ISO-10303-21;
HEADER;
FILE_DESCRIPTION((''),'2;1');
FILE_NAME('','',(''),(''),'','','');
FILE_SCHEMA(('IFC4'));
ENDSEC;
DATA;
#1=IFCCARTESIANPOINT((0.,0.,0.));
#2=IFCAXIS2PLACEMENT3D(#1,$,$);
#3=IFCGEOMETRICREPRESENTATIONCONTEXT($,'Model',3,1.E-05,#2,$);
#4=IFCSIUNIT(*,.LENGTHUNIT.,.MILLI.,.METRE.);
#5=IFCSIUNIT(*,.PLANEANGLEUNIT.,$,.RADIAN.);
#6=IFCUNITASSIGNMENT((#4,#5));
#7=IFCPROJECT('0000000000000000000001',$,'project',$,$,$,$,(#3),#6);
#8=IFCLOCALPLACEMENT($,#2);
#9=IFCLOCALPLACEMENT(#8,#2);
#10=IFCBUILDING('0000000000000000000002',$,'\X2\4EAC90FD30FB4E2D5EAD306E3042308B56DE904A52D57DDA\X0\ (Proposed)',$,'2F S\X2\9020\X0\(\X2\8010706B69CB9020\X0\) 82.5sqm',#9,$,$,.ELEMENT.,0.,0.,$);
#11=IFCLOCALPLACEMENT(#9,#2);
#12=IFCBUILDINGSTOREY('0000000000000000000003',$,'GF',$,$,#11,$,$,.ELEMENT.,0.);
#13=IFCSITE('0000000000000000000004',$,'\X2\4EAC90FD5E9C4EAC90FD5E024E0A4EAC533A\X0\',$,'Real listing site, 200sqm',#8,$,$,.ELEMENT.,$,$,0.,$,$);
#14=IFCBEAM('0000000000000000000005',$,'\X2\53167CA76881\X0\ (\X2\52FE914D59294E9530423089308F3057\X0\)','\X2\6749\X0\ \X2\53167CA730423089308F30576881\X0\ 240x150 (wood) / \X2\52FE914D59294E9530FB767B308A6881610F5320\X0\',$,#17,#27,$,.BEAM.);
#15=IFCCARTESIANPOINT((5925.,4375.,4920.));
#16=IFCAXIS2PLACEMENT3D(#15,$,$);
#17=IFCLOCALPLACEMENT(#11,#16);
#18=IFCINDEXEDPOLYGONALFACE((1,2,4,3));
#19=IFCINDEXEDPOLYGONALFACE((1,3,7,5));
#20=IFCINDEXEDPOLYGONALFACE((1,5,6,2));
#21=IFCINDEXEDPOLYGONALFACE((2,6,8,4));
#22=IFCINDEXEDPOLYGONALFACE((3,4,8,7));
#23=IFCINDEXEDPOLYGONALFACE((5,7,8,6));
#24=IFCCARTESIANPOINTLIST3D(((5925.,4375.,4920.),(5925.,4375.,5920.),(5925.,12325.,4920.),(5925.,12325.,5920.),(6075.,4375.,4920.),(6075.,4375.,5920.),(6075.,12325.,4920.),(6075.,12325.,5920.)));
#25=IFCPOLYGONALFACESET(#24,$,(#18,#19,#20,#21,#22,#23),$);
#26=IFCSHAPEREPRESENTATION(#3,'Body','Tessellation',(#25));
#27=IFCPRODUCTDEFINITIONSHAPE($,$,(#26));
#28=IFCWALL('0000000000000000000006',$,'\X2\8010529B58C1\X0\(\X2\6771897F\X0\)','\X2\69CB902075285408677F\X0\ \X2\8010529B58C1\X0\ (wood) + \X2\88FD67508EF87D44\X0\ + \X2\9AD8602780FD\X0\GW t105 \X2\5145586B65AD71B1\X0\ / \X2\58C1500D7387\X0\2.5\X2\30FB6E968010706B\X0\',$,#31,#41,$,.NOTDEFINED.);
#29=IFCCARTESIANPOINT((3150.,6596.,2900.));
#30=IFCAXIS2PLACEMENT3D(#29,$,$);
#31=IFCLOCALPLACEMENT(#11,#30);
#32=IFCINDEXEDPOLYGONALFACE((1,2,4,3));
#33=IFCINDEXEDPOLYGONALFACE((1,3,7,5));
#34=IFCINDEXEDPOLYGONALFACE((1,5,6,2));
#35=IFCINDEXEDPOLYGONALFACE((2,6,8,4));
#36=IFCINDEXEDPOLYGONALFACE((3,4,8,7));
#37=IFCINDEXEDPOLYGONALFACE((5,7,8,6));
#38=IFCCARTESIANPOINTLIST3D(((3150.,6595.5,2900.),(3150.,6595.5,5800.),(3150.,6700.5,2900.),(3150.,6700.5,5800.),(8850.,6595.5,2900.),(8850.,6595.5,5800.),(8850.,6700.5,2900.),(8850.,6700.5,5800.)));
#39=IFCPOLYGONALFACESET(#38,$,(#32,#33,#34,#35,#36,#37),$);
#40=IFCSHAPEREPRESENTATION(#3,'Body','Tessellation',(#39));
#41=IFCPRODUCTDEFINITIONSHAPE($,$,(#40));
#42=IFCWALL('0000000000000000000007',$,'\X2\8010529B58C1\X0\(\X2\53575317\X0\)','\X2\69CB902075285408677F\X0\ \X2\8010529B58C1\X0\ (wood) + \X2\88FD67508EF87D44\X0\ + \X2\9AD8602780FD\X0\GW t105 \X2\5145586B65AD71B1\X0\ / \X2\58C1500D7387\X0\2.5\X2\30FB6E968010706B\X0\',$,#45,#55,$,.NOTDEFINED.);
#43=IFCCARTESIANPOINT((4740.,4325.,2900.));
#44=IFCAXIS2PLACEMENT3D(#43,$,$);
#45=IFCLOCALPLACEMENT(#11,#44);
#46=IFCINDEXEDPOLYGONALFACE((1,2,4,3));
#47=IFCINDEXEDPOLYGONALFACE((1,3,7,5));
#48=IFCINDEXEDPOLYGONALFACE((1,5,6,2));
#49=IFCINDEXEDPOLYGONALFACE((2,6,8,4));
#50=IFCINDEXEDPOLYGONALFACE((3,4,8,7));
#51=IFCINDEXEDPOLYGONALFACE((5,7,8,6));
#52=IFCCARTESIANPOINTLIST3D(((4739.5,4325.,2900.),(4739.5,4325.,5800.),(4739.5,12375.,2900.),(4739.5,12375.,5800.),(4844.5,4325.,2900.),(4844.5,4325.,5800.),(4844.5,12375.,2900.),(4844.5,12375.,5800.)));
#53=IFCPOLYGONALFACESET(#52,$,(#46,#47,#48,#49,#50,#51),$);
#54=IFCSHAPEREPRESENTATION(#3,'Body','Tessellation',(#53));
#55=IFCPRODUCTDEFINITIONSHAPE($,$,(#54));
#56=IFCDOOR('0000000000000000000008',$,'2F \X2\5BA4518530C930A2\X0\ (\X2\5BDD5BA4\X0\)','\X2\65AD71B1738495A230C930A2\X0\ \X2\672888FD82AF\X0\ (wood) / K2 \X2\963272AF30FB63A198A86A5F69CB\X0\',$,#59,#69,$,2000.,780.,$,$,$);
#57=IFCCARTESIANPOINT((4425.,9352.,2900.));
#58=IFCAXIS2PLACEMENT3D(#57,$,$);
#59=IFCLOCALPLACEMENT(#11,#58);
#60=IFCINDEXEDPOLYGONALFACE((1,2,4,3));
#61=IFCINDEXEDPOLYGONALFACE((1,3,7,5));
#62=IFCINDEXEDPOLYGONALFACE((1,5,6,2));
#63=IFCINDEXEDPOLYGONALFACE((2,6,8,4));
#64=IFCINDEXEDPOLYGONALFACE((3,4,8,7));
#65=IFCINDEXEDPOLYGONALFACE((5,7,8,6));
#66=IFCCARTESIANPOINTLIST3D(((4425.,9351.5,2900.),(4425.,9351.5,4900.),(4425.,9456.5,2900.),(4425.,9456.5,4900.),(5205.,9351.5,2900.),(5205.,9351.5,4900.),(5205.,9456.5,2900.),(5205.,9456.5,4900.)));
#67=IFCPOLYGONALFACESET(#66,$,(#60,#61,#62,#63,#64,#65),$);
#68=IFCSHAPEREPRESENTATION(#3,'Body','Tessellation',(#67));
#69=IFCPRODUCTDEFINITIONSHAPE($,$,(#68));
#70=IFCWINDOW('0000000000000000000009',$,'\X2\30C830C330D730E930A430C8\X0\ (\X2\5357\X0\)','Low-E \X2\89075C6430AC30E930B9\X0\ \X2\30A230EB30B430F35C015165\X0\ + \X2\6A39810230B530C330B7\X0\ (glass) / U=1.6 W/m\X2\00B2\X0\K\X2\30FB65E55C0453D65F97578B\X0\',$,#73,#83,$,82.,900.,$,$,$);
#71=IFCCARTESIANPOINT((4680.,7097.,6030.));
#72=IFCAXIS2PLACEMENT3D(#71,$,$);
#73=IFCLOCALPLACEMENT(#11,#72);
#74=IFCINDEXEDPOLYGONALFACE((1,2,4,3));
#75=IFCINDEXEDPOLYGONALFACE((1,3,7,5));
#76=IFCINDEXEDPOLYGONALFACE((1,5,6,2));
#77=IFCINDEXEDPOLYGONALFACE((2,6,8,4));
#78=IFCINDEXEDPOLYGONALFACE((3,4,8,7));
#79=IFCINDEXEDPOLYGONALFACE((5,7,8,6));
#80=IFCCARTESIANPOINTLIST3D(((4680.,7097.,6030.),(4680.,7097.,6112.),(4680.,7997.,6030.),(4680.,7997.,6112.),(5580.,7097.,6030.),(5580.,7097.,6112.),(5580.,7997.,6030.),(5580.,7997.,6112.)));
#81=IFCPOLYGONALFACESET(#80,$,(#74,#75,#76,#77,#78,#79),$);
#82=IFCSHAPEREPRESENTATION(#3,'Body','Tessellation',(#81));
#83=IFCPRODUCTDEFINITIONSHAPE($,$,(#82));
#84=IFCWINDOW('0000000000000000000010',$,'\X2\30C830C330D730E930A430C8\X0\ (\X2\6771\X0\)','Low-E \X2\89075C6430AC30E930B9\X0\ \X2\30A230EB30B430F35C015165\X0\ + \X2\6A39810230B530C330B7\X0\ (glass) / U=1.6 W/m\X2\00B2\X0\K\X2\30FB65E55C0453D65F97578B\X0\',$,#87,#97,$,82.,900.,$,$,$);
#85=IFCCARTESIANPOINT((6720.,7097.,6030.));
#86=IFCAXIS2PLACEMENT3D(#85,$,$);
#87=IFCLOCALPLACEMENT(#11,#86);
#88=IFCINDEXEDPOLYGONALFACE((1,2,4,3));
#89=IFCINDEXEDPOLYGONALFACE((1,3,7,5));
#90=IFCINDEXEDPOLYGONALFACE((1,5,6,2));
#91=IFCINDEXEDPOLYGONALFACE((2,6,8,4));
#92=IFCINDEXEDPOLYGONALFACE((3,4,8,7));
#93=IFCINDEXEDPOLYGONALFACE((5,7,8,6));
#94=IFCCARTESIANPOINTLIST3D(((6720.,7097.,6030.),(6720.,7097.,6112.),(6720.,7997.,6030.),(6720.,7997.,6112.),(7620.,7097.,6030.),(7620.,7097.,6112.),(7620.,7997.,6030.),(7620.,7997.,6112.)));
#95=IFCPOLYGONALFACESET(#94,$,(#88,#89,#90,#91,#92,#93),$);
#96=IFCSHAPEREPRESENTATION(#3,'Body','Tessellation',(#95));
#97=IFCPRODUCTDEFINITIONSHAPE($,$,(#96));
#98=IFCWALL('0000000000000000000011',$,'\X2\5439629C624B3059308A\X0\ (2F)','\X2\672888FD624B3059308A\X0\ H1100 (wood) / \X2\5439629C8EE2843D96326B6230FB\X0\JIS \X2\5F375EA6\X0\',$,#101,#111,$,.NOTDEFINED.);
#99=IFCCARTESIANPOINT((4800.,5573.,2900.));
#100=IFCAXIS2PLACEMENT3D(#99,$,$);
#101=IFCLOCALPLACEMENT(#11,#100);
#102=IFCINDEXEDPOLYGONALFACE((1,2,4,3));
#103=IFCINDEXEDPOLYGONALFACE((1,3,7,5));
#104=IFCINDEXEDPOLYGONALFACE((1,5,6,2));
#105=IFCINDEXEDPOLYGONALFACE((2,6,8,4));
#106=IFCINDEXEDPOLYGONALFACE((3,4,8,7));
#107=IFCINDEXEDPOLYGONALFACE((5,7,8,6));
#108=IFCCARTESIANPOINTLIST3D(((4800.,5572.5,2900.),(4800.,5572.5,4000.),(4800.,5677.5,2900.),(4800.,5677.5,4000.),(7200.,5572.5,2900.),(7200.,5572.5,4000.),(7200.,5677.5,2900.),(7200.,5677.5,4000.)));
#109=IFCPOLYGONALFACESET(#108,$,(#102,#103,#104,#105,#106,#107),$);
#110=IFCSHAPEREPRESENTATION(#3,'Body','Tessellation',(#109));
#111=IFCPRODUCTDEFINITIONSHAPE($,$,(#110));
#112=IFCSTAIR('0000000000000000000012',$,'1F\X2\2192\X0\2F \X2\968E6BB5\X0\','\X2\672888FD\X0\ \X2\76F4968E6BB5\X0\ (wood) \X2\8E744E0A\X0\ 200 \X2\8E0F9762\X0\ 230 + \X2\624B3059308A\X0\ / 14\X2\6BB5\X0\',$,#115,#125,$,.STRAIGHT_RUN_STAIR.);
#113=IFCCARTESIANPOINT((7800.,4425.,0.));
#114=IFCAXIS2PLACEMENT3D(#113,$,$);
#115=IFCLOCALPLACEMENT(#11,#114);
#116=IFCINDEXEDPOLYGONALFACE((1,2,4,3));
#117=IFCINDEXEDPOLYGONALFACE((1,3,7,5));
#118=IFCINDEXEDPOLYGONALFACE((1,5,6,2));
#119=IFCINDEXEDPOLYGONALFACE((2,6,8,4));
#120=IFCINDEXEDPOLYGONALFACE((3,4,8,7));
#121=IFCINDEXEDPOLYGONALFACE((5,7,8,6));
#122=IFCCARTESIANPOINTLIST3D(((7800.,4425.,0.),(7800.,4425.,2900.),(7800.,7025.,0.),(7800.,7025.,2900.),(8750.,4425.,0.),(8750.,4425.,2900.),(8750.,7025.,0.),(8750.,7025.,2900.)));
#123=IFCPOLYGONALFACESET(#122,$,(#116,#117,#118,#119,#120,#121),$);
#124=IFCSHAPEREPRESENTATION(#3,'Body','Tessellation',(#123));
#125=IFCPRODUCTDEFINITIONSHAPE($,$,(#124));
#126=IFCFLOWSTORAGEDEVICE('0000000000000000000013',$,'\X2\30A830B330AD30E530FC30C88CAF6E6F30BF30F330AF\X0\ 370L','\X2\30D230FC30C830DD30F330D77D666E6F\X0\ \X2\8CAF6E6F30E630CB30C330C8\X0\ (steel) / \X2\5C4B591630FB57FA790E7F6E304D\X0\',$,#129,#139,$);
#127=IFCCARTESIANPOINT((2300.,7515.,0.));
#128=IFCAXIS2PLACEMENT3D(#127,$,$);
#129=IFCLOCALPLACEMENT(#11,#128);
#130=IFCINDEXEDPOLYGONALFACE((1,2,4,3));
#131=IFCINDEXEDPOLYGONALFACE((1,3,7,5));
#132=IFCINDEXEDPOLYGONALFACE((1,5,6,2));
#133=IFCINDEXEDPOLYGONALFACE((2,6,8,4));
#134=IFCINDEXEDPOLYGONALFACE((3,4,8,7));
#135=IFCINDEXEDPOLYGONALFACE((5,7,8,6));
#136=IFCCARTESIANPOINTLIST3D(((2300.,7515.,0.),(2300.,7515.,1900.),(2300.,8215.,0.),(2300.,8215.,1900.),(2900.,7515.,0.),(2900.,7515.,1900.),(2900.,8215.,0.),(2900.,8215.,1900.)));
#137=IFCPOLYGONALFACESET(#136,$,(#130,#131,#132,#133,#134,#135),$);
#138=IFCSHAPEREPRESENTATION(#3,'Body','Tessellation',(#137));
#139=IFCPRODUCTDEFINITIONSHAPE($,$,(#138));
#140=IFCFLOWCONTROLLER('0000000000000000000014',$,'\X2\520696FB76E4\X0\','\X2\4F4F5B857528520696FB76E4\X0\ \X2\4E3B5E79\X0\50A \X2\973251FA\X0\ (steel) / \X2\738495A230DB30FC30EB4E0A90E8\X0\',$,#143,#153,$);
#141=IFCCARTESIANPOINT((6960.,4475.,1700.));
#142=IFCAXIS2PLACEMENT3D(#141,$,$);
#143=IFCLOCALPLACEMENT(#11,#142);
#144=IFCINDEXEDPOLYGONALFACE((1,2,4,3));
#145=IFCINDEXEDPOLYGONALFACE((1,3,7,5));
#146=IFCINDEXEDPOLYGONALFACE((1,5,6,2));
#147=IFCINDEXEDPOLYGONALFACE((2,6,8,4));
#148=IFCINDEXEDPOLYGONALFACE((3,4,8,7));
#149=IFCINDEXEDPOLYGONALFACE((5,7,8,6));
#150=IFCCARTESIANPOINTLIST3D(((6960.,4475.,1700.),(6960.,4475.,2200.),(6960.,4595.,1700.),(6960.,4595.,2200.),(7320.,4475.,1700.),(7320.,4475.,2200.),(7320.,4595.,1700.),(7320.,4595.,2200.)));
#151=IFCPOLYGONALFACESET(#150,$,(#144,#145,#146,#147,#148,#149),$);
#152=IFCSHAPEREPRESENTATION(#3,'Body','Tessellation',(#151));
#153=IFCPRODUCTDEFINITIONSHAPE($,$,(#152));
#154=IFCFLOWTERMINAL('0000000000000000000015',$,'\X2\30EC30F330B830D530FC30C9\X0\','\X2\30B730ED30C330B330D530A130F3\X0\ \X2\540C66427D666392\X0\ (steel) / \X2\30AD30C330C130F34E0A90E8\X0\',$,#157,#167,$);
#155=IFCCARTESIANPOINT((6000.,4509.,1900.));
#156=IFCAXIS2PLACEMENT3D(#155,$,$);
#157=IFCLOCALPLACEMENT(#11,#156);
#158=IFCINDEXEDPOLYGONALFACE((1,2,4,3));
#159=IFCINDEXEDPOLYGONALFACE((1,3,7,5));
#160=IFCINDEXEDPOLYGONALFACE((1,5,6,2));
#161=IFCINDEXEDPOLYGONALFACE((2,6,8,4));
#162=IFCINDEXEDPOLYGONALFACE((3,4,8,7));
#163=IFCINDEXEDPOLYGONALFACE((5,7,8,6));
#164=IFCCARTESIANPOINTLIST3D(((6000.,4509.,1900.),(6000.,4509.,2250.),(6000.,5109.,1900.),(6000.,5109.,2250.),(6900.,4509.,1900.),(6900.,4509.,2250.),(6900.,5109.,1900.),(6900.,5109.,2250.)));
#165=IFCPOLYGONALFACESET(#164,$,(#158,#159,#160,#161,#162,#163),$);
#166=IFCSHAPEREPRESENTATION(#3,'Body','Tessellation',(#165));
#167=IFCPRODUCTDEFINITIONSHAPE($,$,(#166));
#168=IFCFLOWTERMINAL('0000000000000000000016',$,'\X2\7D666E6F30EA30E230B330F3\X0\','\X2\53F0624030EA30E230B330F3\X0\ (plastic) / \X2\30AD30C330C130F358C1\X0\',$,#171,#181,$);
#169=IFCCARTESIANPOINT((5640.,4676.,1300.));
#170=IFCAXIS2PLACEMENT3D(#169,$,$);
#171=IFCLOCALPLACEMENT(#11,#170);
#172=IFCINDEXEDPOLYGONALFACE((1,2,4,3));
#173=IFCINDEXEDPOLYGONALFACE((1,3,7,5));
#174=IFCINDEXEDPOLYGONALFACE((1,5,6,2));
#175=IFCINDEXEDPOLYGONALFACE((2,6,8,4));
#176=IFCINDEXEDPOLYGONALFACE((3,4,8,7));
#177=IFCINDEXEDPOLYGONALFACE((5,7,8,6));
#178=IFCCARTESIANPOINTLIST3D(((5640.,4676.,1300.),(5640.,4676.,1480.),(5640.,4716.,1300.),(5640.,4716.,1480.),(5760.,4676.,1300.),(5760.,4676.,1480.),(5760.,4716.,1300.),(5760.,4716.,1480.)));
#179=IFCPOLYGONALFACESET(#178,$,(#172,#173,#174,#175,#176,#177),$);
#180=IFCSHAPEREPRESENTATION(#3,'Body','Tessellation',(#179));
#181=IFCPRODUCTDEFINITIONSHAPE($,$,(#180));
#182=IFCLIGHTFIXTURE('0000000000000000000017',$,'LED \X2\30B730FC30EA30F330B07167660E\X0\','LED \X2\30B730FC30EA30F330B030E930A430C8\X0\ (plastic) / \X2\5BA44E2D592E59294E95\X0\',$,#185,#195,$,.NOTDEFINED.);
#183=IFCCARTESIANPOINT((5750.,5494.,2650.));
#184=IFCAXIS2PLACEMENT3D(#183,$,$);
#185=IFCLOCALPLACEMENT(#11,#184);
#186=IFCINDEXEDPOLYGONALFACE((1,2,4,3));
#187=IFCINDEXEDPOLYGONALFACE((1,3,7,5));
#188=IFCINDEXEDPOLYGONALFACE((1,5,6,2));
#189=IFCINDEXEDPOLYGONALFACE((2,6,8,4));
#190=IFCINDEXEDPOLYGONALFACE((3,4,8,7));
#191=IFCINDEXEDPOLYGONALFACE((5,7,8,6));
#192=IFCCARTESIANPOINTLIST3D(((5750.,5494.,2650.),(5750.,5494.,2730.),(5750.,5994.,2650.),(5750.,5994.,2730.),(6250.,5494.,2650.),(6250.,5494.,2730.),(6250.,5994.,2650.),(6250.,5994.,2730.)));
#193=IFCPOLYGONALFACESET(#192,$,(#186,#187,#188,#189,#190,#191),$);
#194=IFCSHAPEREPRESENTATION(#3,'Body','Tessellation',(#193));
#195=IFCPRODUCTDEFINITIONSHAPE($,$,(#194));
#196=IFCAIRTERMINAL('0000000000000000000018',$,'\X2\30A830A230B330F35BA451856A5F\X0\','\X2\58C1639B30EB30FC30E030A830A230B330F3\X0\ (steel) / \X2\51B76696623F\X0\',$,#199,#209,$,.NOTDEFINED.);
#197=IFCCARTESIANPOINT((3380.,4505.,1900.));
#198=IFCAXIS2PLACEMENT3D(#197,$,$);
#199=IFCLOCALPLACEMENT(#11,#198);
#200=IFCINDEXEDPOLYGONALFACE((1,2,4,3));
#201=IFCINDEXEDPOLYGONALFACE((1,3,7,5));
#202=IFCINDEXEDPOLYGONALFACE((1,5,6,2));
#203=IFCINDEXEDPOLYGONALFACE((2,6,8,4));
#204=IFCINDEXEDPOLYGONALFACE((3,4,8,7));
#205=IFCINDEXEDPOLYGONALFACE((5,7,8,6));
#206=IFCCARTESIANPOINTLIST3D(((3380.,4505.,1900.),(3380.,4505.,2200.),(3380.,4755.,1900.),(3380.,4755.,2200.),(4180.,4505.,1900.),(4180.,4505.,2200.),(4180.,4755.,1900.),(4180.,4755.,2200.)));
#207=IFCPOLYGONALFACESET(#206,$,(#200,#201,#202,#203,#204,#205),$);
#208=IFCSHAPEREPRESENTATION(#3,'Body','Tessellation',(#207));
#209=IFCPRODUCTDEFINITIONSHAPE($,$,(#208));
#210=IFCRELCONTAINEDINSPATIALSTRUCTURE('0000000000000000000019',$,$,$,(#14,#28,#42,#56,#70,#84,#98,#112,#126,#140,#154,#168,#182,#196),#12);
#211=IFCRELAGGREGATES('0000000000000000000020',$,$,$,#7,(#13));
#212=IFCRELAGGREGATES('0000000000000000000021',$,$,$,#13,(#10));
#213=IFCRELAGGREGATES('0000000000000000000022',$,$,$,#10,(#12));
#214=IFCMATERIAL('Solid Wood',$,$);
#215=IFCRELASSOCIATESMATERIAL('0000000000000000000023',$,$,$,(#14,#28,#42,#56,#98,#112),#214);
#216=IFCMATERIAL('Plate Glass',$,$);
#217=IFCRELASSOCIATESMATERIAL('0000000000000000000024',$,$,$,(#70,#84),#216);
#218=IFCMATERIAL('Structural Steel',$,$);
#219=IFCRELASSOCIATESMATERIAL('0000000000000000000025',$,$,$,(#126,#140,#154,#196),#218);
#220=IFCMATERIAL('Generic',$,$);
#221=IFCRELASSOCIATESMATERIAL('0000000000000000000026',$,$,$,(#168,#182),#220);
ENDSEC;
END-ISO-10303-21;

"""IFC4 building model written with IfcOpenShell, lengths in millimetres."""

from ifc_helpers import new_model, si_unit, frame, frame_2d, origin, place, context, project, spatial, rectangle, extrude, material, element, fill, save


model = new_model("IFC4")

# Units and contexts
model_context = context("Model", 3, precision=1e-05, world=origin())
ifc_project = project(units=[si_unit("LENGTHUNIT", "METRE", prefix="MILLI"), si_unit("PLANEANGLEUNIT", "RADIAN")], contexts=[model_context])

# Site, building, storey
site_placement = place(None, origin())
site = spatial("IfcSite", under=ifc_project, at=site_placement, Name="京都府京都市上京区", ObjectType="Real listing site, 200sqm", CompositionType="ELEMENT", RefElevation=0.0)
building_placement = place(site_placement, origin())
building = spatial("IfcBuilding", under=site, at=building_placement, Name="京都・中庭のある回遊動線 (Proposed)", ObjectType="2F S造(耐火構造) 82.5sqm", CompositionType="ELEMENT", ElevationOfRefHeight=0.0, ElevationOfTerrain=0.0)
storey_placement = place(building_placement, origin())
storey = spatial("IfcBuildingStorey", under=building, at=storey_placement, Name="GF", CompositionType="ELEMENT", Elevation=0.0)

# Shared definitions
ifc_material_1 = material(Name="Solid Wood")

# Beam
beam_placement = place(storey_placement, frame((5925.0, 4375.0, 4920.0)))
element("IfcBeam", 1, at=beam_placement, inside=storey, material=ifc_material_1, Name="化粧梁 (勾配天井あらわし)", Description="杉 化粧あらわし梁 240x150 (wood) / 勾配天井・登り梁意匠", PredefinedType="BEAM", context=model_context, shape_type="SweptSolid", body=[
    extrude(rectangle(XDim=150.0, YDim=7950.0, at=frame_2d((75.0, 3975.0))), frame((5925.0, 4375.0, 4920.0)), (0.0, 0.0, 1.0), 1000.0),
])

# Wall
wall_1_placement = place(storey_placement, frame((3150.0, 6596.0, 2900.0)))
element("IfcWall", 2, at=wall_1_placement, inside=storey, material=ifc_material_1, Name="耐力壁(東西)", Description="構造用合板 耐力壁 (wood) + 製材軸組 + 高性能GW t105 充填断熱 / 壁倍率2.5・準耐火", PredefinedType="NOTDEFINED", context=model_context, shape_type="SweptSolid", body=[
    extrude(rectangle(XDim=5700.0, YDim=105.0, at=frame_2d((2850.0, 52.0))), frame((3150.0, 6596.0, 2900.0)), (0.0, 0.0, 1.0), 2900.0),
])

# Wall, opening, door
wall_2_placement = place(storey_placement, frame((4740.0, 4325.0, 2900.0)))
wall_2 = element("IfcWall", 3, at=wall_2_placement, inside=storey, material=ifc_material_1, Name="耐力壁(南北)", Description="構造用合板 耐力壁 (wood) + 製材軸組 + 高性能GW t105 充填断熱 / 壁倍率2.5・準耐火", PredefinedType="NOTDEFINED", context=model_context, shape_type="SweptSolid", body=[
    extrude(rectangle(XDim=105.0, YDim=8050.0, at=frame_2d((52.0, 4025.0))), frame((4740.0, 4325.0, 2900.0)), (0.0, 0.0, 1.0), 2900.0),
])
opening_placement = place(storey_placement, frame((4425.0, 9352.0, 2900.0)))
opening = element("IfcOpeningElement", 4, at=opening_placement, cuts=wall_2, PredefinedType="NOTDEFINED", context=model_context, shape_type="SweptSolid", body=[
    extrude(rectangle(XDim=780.0, YDim=105.0, at=frame_2d((390.0, 52.0))), frame((4425.0, 9352.0, 2900.0)), (0.0, 0.0, 1.0), 2000.0),
])
door_placement = place(storey_placement, frame((4425.0, 9352.0, 2900.0)))
door = element("IfcDoor", 5, at=door_placement, inside=storey, material=ifc_material_1, Name="2F 室内ドア (寝室)", Description="断熱玄関ドア 木製芯 (wood) / K2 防犯・採風機構", OverallHeight=2000.0, OverallWidth=780.0, context=model_context, shape_type="SweptSolid", body=[
    extrude(rectangle(XDim=780.0, YDim=105.0, at=frame_2d((390.0, 52.0))), frame((4425.0, 9352.0, 2900.0)), (0.0, 0.0, 1.0), 2000.0),
])
fill(opening, door)

# Windows
ifc_material_2 = material(Name="Plate Glass")
window_1_placement = place(storey_placement, frame((4680.0, 7097.0, 6030.0)))
element("IfcWindow", 6, at=window_1_placement, inside=storey, material=ifc_material_2, Name="トップライト (南)", Description="Low-E 複層ガラス アルゴン封入 + 樹脂サッシ (glass) / U=1.6 W/m²K・日射取得型", OverallHeight=82.0, OverallWidth=900.0, context=model_context, shape_type="SweptSolid", body=[
    extrude(rectangle(XDim=900.0, YDim=900.0, at=frame_2d((450.0, 450.0))), frame((4680.0, 7097.0, 6030.0)), (0.0, 0.0, 1.0), 82.0),
])
window_2_placement = place(storey_placement, frame((6720.0, 7097.0, 6030.0)))
element("IfcWindow", 7, at=window_2_placement, inside=storey, material=ifc_material_2, Name="トップライト (東)", Description="Low-E 複層ガラス アルゴン封入 + 樹脂サッシ (glass) / U=1.6 W/m²K・日射取得型", OverallHeight=82.0, OverallWidth=900.0, context=model_context, shape_type="SweptSolid", body=[
    extrude(rectangle(XDim=900.0, YDim=900.0, at=frame_2d((450.0, 450.0))), frame((6720.0, 7097.0, 6030.0)), (0.0, 0.0, 1.0), 82.0),
])

# Wall
wall_3_placement = place(storey_placement, frame((4800.0, 5573.0, 2900.0)))
element("IfcWall", 8, at=wall_3_placement, inside=storey, material=ifc_material_1, Name="吹抜手すり (2F)", Description="木製手すり H1100 (wood) / 吹抜転落防止・JIS 強度", PredefinedType="NOTDEFINED", context=model_context, shape_type="SweptSolid", body=[
    extrude(rectangle(XDim=2400.0, YDim=105.0, at=frame_2d((1200.0, 52.0))), frame((4800.0, 5573.0, 2900.0)), (0.0, 0.0, 1.0), 1100.0),
])

# Stair
stair_placement = place(storey_placement, frame((7800.0, 4425.0, 0.0)))
element("IfcStair", 9, at=stair_placement, inside=storey, material=ifc_material_1, Name="1F→2F 階段", Description="木製 直階段 (wood) 蹴上 200 踏面 230 + 手すり / 14段", PredefinedType="STRAIGHT_RUN_STAIR", context=model_context, shape_type="SweptSolid", body=[
    extrude(rectangle(XDim=950.0, YDim=2600.0, at=frame_2d((475.0, 1300.0))), frame((7800.0, 4425.0, 0.0)), (0.0, 0.0, 1.0), 2900.0),
])

# Flow storage device
ifc_material_3 = material(Name="Structural Steel")
flow_storage_device_placement = place(storey_placement, frame((2300.0, 7515.0, 0.0)))
element("IfcFlowStorageDevice", 10, at=flow_storage_device_placement, inside=storey, material=ifc_material_3, Name="エコキュート貯湯タンク 370L", Description="ヒートポンプ給湯 貯湯ユニット (steel) / 屋外・基礎置き", context=model_context, shape_type="SweptSolid", body=[
    extrude(rectangle(XDim=600.0, YDim=700.0, at=frame_2d((300.0, 350.0))), frame((2300.0, 7515.0, 0.0)), (0.0, 0.0, 1.0), 1900.0),
])

# Flow controller
flow_controller_placement = place(storey_placement, frame((6960.0, 4475.0, 1700.0)))
element("IfcFlowController", 11, at=flow_controller_placement, inside=storey, material=ifc_material_3, Name="分電盤", Description="住宅用分電盤 主幹50A 露出 (steel) / 玄関ホール上部", context=model_context, shape_type="SweptSolid", body=[
    extrude(rectangle(XDim=360.0, YDim=120.0, at=frame_2d((180.0, 60.0))), frame((6960.0, 4475.0, 1700.0)), (0.0, 0.0, 1.0), 500.0),
])

# Flow terminals
flow_terminal_1_placement = place(storey_placement, frame((6000.0, 4509.0, 1900.0)))
element("IfcFlowTerminal", 12, at=flow_terminal_1_placement, inside=storey, material=ifc_material_3, Name="レンジフード", Description="シロッコファン 同時給排 (steel) / キッチン上部", context=model_context, shape_type="SweptSolid", body=[
    extrude(rectangle(XDim=900.0, YDim=600.0, at=frame_2d((450.0, 300.0))), frame((6000.0, 4509.0, 1900.0)), (0.0, 0.0, 1.0), 350.0),
])
ifc_material_4 = material(Name="Generic")
flow_terminal_2_placement = place(storey_placement, frame((5640.0, 4676.0, 1300.0)))
element("IfcFlowTerminal", 13, at=flow_terminal_2_placement, inside=storey, material=ifc_material_4, Name="給湯リモコン", Description="台所リモコン (plastic) / キッチン壁", context=model_context, shape_type="SweptSolid", body=[
    extrude(rectangle(XDim=120.0, YDim=40.0, at=frame_2d((60.0, 20.0))), frame((5640.0, 4676.0, 1300.0)), (0.0, 0.0, 1.0), 180.0),
])

# Light fixture
light_fixture_1_placement = place(storey_placement, frame((5750.0, 5494.0, 2650.0)))
element("IfcLightFixture", 14, at=light_fixture_1_placement, inside=storey, material=ifc_material_4, Name="LED シーリング照明", Description="LED シーリングライト (plastic) / 室中央天井", PredefinedType="NOTDEFINED", context=model_context, shape_type="SweptSolid", body=[
    extrude(rectangle(XDim=500.0, YDim=500.0, at=frame_2d((250.0, 250.0))), frame((5750.0, 5494.0, 2650.0)), (0.0, 0.0, 1.0), 80.0),
])

# Air terminal
air_terminal_1_placement = place(storey_placement, frame((3380.0, 4505.0, 1900.0)))
element("IfcAirTerminal", 15, at=air_terminal_1_placement, inside=storey, material=ifc_material_3, Name="エアコン室内機", Description="壁掛ルームエアコン (steel) / 冷暖房", PredefinedType="NOTDEFINED", context=model_context, shape_type="SweptSolid", body=[
    extrude(rectangle(XDim=800.0, YDim=250.0, at=frame_2d((400.0, 125.0))), frame((3380.0, 4505.0, 1900.0)), (0.0, 0.0, 1.0), 300.0),
])

save(model, "model.ifc")
